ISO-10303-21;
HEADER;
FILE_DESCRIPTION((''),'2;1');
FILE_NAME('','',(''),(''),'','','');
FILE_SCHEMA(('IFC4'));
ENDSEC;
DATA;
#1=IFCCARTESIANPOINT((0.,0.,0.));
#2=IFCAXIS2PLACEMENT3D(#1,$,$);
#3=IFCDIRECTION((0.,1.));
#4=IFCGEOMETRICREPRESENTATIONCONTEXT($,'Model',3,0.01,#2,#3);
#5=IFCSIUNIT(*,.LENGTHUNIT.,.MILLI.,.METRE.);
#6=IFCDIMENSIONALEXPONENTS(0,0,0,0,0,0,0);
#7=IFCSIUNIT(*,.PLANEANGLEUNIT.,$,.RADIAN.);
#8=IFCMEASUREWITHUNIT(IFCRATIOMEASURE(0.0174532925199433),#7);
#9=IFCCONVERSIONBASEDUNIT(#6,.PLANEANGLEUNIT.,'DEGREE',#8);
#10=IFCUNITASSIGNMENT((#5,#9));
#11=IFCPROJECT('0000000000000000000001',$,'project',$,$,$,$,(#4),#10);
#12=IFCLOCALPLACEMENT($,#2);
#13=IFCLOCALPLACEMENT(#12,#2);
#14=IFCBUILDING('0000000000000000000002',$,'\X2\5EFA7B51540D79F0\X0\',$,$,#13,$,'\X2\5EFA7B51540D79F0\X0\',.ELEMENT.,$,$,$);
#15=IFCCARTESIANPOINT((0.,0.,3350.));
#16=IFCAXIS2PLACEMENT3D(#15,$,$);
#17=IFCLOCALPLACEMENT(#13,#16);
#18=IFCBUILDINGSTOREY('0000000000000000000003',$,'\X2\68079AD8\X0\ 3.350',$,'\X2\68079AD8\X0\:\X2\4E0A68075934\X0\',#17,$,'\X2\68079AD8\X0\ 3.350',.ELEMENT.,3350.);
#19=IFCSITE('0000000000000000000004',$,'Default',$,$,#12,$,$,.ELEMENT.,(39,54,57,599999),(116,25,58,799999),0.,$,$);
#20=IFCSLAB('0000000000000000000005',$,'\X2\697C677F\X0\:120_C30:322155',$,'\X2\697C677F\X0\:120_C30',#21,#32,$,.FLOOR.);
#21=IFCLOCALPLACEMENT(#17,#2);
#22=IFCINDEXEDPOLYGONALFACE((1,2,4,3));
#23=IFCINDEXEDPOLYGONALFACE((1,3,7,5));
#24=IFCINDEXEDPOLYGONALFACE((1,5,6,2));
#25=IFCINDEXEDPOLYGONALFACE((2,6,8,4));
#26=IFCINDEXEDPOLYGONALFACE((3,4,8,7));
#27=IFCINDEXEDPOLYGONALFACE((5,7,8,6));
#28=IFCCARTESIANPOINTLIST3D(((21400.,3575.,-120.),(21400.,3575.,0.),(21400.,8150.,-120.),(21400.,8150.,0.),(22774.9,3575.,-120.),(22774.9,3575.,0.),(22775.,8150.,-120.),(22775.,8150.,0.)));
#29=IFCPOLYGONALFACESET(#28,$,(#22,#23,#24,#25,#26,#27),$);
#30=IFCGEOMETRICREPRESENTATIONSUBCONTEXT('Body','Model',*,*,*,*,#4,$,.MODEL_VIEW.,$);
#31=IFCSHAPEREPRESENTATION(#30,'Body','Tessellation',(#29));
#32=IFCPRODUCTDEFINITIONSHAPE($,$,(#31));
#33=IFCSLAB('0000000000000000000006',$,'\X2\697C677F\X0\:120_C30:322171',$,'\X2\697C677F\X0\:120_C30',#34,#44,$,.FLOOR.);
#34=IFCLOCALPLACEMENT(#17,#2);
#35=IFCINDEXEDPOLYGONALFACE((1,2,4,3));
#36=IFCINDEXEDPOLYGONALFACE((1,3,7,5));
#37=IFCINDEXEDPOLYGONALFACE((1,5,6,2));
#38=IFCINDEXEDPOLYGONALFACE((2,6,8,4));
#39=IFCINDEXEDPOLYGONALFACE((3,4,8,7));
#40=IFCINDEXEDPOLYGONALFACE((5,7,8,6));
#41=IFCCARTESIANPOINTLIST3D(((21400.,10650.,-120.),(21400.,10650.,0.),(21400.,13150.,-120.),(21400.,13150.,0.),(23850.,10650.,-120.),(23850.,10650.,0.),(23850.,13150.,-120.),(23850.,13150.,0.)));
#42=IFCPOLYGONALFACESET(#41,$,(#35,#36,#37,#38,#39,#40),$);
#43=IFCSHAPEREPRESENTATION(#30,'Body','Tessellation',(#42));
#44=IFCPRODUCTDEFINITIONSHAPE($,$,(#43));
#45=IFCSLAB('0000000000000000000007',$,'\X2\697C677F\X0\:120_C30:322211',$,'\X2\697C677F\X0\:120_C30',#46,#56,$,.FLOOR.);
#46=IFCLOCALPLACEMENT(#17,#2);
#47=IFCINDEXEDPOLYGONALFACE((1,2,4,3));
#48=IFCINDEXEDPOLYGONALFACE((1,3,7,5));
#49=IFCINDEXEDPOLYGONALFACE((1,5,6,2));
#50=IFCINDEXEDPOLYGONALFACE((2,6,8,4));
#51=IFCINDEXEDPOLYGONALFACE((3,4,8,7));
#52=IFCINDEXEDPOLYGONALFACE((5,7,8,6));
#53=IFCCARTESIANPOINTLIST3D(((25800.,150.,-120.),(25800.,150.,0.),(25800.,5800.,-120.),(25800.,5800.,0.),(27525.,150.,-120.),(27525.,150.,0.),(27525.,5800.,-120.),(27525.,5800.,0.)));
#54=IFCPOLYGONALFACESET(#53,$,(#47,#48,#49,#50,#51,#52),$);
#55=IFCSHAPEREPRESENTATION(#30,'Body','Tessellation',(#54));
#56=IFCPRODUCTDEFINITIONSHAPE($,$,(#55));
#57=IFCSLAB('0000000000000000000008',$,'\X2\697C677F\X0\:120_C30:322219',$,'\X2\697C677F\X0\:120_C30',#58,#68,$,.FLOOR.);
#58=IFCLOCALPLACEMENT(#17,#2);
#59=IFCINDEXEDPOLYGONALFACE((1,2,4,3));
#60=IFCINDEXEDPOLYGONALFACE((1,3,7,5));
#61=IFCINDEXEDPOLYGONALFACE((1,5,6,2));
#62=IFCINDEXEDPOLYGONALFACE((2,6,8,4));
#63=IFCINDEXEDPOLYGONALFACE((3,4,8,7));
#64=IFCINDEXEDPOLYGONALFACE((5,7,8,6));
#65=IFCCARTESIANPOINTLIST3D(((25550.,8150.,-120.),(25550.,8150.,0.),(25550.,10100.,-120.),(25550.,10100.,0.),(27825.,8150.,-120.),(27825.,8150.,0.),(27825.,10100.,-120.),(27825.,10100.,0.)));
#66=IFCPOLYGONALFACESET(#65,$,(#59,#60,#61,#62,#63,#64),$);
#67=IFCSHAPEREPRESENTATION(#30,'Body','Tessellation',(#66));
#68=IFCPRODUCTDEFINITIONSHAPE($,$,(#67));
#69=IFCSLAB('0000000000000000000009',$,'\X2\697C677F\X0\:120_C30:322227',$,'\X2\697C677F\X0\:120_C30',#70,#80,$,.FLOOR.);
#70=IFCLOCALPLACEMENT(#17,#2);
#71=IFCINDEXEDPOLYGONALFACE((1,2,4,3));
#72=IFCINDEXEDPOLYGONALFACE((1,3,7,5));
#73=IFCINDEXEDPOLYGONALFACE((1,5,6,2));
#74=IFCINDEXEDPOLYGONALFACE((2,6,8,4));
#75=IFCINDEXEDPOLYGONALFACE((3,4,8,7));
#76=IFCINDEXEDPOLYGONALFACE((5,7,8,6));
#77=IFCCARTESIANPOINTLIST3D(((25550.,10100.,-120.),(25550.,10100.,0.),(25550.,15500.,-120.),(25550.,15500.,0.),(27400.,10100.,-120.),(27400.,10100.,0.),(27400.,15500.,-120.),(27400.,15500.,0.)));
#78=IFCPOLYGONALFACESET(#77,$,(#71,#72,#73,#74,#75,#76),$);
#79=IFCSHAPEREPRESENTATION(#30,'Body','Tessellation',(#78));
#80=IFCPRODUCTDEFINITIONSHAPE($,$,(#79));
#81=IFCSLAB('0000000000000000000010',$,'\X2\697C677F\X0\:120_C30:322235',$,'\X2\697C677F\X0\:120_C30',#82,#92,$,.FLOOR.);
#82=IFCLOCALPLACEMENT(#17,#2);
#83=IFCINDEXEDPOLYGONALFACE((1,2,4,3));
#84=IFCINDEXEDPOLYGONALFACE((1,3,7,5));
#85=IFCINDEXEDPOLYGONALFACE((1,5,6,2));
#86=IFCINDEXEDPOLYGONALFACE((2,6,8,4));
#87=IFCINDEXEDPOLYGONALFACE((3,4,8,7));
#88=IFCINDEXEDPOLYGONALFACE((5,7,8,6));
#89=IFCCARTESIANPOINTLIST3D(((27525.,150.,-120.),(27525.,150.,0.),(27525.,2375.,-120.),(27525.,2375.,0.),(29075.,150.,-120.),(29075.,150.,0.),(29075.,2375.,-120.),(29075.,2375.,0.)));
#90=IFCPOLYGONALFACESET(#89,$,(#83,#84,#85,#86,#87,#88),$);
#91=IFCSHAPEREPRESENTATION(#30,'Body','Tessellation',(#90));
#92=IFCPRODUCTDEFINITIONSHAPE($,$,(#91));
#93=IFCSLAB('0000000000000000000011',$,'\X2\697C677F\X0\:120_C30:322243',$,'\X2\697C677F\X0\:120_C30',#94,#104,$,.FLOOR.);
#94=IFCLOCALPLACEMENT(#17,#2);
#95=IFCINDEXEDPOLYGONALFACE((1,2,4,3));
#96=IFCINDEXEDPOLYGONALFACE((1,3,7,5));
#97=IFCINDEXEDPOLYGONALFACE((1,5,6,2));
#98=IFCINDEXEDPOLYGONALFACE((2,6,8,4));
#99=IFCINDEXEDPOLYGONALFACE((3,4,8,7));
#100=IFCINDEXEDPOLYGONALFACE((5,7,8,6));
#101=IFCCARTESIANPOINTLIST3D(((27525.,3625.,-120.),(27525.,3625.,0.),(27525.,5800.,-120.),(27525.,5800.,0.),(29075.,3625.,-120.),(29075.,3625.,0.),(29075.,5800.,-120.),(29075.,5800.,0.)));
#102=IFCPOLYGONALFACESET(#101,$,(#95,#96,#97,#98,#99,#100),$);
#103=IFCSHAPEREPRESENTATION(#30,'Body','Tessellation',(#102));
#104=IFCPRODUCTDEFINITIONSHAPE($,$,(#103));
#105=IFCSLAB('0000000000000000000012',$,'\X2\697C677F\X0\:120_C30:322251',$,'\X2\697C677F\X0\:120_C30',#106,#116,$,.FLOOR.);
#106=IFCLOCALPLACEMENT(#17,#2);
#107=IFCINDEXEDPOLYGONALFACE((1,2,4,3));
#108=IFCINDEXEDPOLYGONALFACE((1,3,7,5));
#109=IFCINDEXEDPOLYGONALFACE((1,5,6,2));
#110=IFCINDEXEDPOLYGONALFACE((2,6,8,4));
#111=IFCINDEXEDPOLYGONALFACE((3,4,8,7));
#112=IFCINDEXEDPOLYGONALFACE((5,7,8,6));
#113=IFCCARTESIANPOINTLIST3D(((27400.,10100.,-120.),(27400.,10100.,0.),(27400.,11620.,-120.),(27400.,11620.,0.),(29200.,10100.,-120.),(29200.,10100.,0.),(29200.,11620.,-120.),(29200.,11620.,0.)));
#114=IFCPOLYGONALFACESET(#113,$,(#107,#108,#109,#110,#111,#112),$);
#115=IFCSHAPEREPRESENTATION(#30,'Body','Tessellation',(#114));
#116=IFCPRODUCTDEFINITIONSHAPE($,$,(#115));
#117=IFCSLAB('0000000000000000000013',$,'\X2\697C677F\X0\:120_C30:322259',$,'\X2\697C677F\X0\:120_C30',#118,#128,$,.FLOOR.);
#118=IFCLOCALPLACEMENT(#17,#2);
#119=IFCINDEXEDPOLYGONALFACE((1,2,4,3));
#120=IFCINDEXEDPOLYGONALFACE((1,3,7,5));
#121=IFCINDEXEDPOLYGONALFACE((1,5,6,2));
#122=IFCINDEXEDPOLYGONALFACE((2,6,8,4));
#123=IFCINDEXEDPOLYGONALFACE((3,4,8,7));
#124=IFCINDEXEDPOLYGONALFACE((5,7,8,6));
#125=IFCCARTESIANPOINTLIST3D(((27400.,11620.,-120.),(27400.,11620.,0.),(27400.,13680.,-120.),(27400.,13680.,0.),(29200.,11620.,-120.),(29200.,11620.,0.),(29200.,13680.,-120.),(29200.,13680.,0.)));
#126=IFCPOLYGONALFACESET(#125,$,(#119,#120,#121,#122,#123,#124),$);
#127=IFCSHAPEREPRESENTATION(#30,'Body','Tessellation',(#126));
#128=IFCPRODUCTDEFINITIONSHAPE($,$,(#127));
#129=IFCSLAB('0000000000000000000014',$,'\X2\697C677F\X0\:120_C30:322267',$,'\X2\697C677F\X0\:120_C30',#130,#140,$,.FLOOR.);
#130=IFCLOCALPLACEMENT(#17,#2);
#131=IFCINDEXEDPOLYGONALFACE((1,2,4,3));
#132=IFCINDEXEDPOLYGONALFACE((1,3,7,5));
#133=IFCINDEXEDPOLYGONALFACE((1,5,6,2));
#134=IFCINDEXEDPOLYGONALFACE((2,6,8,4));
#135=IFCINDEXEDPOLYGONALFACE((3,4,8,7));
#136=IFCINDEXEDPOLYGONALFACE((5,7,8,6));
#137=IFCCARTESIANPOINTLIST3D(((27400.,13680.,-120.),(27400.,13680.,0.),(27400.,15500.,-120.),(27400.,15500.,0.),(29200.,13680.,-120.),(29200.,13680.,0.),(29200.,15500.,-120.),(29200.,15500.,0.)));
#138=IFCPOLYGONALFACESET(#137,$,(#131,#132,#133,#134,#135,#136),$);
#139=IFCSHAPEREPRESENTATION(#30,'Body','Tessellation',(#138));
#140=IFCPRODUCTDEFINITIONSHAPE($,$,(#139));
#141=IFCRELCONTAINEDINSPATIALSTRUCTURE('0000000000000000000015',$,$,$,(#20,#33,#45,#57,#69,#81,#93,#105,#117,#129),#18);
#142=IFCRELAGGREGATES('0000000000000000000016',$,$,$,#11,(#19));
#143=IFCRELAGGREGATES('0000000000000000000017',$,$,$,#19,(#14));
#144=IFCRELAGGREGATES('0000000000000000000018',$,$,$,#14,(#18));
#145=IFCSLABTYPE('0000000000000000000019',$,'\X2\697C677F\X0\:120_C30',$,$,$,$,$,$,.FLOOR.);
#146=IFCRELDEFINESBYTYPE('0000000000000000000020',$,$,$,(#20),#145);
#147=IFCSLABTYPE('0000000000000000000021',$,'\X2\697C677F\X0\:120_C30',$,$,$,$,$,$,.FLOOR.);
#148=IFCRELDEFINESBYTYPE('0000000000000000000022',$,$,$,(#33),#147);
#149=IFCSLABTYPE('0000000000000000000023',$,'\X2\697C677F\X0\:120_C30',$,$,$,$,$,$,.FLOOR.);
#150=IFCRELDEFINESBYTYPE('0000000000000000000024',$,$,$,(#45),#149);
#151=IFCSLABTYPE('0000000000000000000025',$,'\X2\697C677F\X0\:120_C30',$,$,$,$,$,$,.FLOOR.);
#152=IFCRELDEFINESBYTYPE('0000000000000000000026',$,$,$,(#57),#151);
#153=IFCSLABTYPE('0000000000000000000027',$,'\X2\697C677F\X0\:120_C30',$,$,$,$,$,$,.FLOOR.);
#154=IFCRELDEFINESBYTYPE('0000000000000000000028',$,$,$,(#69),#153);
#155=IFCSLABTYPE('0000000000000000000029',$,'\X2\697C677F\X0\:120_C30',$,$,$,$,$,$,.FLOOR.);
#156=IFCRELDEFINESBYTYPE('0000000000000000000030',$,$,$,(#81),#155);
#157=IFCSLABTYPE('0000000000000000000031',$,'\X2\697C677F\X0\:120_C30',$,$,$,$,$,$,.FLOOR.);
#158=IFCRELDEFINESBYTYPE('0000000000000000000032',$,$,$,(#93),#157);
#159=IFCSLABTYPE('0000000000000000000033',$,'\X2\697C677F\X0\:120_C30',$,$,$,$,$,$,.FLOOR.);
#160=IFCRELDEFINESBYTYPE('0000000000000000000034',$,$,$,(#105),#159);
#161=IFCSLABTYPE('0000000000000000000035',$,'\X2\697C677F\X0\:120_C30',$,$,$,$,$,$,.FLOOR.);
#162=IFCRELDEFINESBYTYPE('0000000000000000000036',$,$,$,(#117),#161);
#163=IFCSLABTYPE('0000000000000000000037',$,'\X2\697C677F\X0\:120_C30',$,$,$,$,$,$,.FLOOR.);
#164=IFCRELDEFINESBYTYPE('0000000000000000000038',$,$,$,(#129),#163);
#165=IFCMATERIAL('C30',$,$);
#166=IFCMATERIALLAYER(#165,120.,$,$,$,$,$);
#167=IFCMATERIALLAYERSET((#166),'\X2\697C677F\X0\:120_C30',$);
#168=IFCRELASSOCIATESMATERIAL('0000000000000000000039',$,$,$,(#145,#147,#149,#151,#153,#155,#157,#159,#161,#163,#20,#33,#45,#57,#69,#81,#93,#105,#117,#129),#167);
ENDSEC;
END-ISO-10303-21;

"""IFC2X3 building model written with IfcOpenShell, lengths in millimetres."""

from ifc_helpers import new_model, entity, si_unit, converted_unit, direction, frame, frame_2d, origin, place, context, subcontext, project, spatial, polyline, rectangle, outline, extrude, material, layer, layer_set, layer_usage, type_object, element, save


model = new_model("IFC2X3")

# Units and contexts
model_context = context("Model", 3, precision=0.01, world=origin(), true_north=direction((0.0, 1.0)))
body_context = subcontext(model_context, "Body", "Model", "MODEL_VIEW")
ifc_project = project(units=[si_unit("LENGTHUNIT", "METRE", prefix="MILLI"), converted_unit("PLANEANGLEUNIT", "DEGREE", entity("IfcRatioMeasure", 0.0174532925199433), si_unit("PLANEANGLEUNIT", "RADIAN"), dimensions=[0, 0, 0, 0, 0, 0, 0])], contexts=[model_context])

# Site, building, storey
site_placement = place(None, origin())
site = spatial("IfcSite", under=ifc_project, at=site_placement, Name="Default", CompositionType="ELEMENT", RefLatitude=(39, 54, 57, 599999), RefLongitude=(116, 25, 58, 799999), RefElevation=0.0)
building_placement = place(site_placement, origin())
building = spatial("IfcBuilding", under=site, at=building_placement, Name="建筑名称", LongName="建筑名称", CompositionType="ELEMENT")
storey_placement = place(building_placement, frame((0.0, 0.0, 3350.0)))
storey = spatial("IfcBuildingStorey", under=building, at=storey_placement, Name="标高 3.350", ObjectType="标高:上标头", LongName="标高 3.350", CompositionType="ELEMENT", Elevation=3350.0)

# Slabs
ifc_material = material(Name="C30")
ifc_layer = layer(ifc_material, 120.0)
ifc_layer_set = layer_set([ifc_layer], Name="楼板:120_C30")
ifc_layer_usage_1 = layer_usage(ifc_layer_set, "AXIS3", "POSITIVE", 0.0)
slab_type_1 = type_object("IfcSlabType", Name="楼板:120_C30", PredefinedType="FLOOR", material=ifc_layer_set)
slab_1_placement = place(storey_placement, origin())
element("IfcSlab", 1, at=slab_1_placement, inside=storey, type_object=slab_type_1, material=ifc_layer_usage_1, Name="楼板:120_C30:322155", ObjectType="楼板:120_C30", PredefinedType="FLOOR", context=body_context, shape_type="SweptSolid", body=[
    extrude(outline(polyline([(-2287.5, -687.5), (2287.5, -687.5), (2287.5, 687.5), (-2287.5, 687.4), (-2287.5, -687.5)])), frame((22087.5, 5862.5, 0.0), z_axis=(0.0, 0.0, -1.0), x_axis=(0.0, 1.0, 0.0)), (0.0, 0.0, 1.0), 120.0),
])
ifc_layer_usage_2 = layer_usage(ifc_layer_set, "AXIS3", "POSITIVE", 0.0)
slab_type_2 = type_object("IfcSlabType", Name="楼板:120_C30", PredefinedType="FLOOR", material=ifc_layer_set)
slab_2_placement = place(storey_placement, origin())
element("IfcSlab", 2, at=slab_2_placement, inside=storey, type_object=slab_type_2, material=ifc_layer_usage_2, Name="楼板:120_C30:322171", ObjectType="楼板:120_C30", PredefinedType="FLOOR", context=body_context, shape_type="SweptSolid", body=[
    extrude(rectangle(XDim=2500.0, YDim=2450.0, at=frame_2d((0.0, 0.0), x_axis=(1.0, 0.0))), frame((22625.0, 11900.0, 0.0), z_axis=(0.0, 0.0, -1.0), x_axis=(0.0, 1.0, 0.0)), (0.0, 0.0, 1.0), 120.0),
])
ifc_layer_usage_3 = layer_usage(ifc_layer_set, "AXIS3", "POSITIVE", 0.0)
slab_type_3 = type_object("IfcSlabType", Name="楼板:120_C30", PredefinedType="FLOOR", material=ifc_layer_set)
slab_3_placement = place(storey_placement, origin())
element("IfcSlab", 3, at=slab_3_placement, inside=storey, type_object=slab_type_3, material=ifc_layer_usage_3, Name="楼板:120_C30:322211", ObjectType="楼板:120_C30", PredefinedType="FLOOR", context=body_context, shape_type="SweptSolid", body=[
    extrude(rectangle(XDim=5650.0, YDim=1725.0, at=frame_2d((0.0, 0.0), x_axis=(1.0, 0.0))), frame((26662.5, 2975.0, 0.0), z_axis=(0.0, 0.0, -1.0), x_axis=(0.0, 1.0, 0.0)), (0.0, 0.0, 1.0), 120.0),
])
ifc_layer_usage_4 = layer_usage(ifc_layer_set, "AXIS3", "POSITIVE", 0.0)
slab_type_4 = type_object("IfcSlabType", Name="楼板:120_C30", PredefinedType="FLOOR", material=ifc_layer_set)
slab_4_placement = place(storey_placement, origin())
element("IfcSlab", 4, at=slab_4_placement, inside=storey, type_object=slab_type_4, material=ifc_layer_usage_4, Name="楼板:120_C30:322219", ObjectType="楼板:120_C30", PredefinedType="FLOOR", context=body_context, shape_type="SweptSolid", body=[
    extrude(rectangle(XDim=1950.0, YDim=2275.0, at=frame_2d((0.0, 0.0), x_axis=(1.0, 0.0))), frame((26687.5, 9125.0, 0.0), z_axis=(0.0, 0.0, -1.0), x_axis=(0.0, 1.0, 0.0)), (0.0, 0.0, 1.0), 120.0),
])
ifc_layer_usage_5 = layer_usage(ifc_layer_set, "AXIS3", "POSITIVE", 0.0)
slab_type_5 = type_object("IfcSlabType", Name="楼板:120_C30", PredefinedType="FLOOR", material=ifc_layer_set)
slab_5_placement = place(storey_placement, origin())
element("IfcSlab", 5, at=slab_5_placement, inside=storey, type_object=slab_type_5, material=ifc_layer_usage_5, Name="楼板:120_C30:322227", ObjectType="楼板:120_C30", PredefinedType="FLOOR", context=body_context, shape_type="SweptSolid", body=[
    extrude(rectangle(XDim=5400.0, YDim=1850.0, at=frame_2d((0.0, 0.0), x_axis=(1.0, 0.0))), frame((26475.0, 12800.0, 0.0), z_axis=(0.0, 0.0, -1.0), x_axis=(0.0, 1.0, 0.0)), (0.0, 0.0, 1.0), 120.0),
])
ifc_layer_usage_6 = layer_usage(ifc_layer_set, "AXIS3", "POSITIVE", 0.0)
slab_type_6 = type_object("IfcSlabType", Name="楼板:120_C30", PredefinedType="FLOOR", material=ifc_layer_set)
slab_6_placement = place(storey_placement, origin())
element("IfcSlab", 6, at=slab_6_placement, inside=storey, type_object=slab_type_6, material=ifc_layer_usage_6, Name="楼板:120_C30:322235", ObjectType="楼板:120_C30", PredefinedType="FLOOR", context=body_context, shape_type="SweptSolid", body=[
    extrude(rectangle(XDim=2225.0, YDim=1550.0, at=frame_2d((0.0, 0.0), x_axis=(1.0, 0.0))), frame((28300.0, 1262.5, 0.0), z_axis=(0.0, 0.0, -1.0), x_axis=(0.0, 1.0, 0.0)), (0.0, 0.0, 1.0), 120.0),
])
ifc_layer_usage_7 = layer_usage(ifc_layer_set, "AXIS3", "POSITIVE", 0.0)
slab_type_7 = type_object("IfcSlabType", Name="楼板:120_C30", PredefinedType="FLOOR", material=ifc_layer_set)
slab_7_placement = place(storey_placement, origin())
element("IfcSlab", 7, at=slab_7_placement, inside=storey, type_object=slab_type_7, material=ifc_layer_usage_7, Name="楼板:120_C30:322243", ObjectType="楼板:120_C30", PredefinedType="FLOOR", context=body_context, shape_type="SweptSolid", body=[
    extrude(rectangle(XDim=2175.0, YDim=1550.0, at=frame_2d((0.0, 0.0), x_axis=(1.0, 0.0))), frame((28300.0, 4712.5, 0.0), z_axis=(0.0, 0.0, -1.0), x_axis=(0.0, 1.0, 0.0)), (0.0, 0.0, 1.0), 120.0),
])
ifc_layer_usage_8 = layer_usage(ifc_layer_set, "AXIS3", "POSITIVE", 0.0)
slab_type_8 = type_object("IfcSlabType", Name="楼板:120_C30", PredefinedType="FLOOR", material=ifc_layer_set)
slab_8_placement = place(storey_placement, origin())
element("IfcSlab", 8, at=slab_8_placement, inside=storey, type_object=slab_type_8, material=ifc_layer_usage_8, Name="楼板:120_C30:322251", ObjectType="楼板:120_C30", PredefinedType="FLOOR", context=body_context, shape_type="SweptSolid", body=[
    extrude(rectangle(XDim=1520.0, YDim=1800.0, at=frame_2d((0.0, 0.0), x_axis=(1.0, 0.0))), frame((28300.0, 10860.0, 0.0), z_axis=(0.0, 0.0, -1.0), x_axis=(0.0, 1.0, 0.0)), (0.0, 0.0, 1.0), 120.0),
])
ifc_layer_usage_9 = layer_usage(ifc_layer_set, "AXIS3", "POSITIVE", 0.0)
slab_type_9 = type_object("IfcSlabType", Name="楼板:120_C30", PredefinedType="FLOOR", material=ifc_layer_set)
slab_9_placement = place(storey_placement, origin())
element("IfcSlab", 9, at=slab_9_placement, inside=storey, type_object=slab_type_9, material=ifc_layer_usage_9, Name="楼板:120_C30:322259", ObjectType="楼板:120_C30", PredefinedType="FLOOR", context=body_context, shape_type="SweptSolid", body=[
    extrude(rectangle(XDim=2060.0, YDim=1800.0, at=frame_2d((0.0, 0.0), x_axis=(1.0, 0.0))), frame((28300.0, 12650.0, 0.0), z_axis=(0.0, 0.0, -1.0), x_axis=(0.0, 1.0, 0.0)), (0.0, 0.0, 1.0), 120.0),
])
ifc_layer_usage_10 = layer_usage(ifc_layer_set, "AXIS3", "POSITIVE", 0.0)
slab_type_10 = type_object("IfcSlabType", Name="楼板:120_C30", PredefinedType="FLOOR", material=ifc_layer_set)
slab_10_placement = place(storey_placement, origin())
element("IfcSlab", 10, at=slab_10_placement, inside=storey, type_object=slab_type_10, material=ifc_layer_usage_10, Name="楼板:120_C30:322267", ObjectType="楼板:120_C30", PredefinedType="FLOOR", context=body_context, shape_type="SweptSolid", body=[
    extrude(rectangle(XDim=1820.0, YDim=1800.0, at=frame_2d((0.0, 0.0), x_axis=(1.0, 0.0))), frame((28300.0, 14590.0, 0.0), z_axis=(0.0, 0.0, -1.0), x_axis=(0.0, 1.0, 0.0)), (0.0, 0.0, 1.0), 120.0),
])

save(model, "model.ifc")
